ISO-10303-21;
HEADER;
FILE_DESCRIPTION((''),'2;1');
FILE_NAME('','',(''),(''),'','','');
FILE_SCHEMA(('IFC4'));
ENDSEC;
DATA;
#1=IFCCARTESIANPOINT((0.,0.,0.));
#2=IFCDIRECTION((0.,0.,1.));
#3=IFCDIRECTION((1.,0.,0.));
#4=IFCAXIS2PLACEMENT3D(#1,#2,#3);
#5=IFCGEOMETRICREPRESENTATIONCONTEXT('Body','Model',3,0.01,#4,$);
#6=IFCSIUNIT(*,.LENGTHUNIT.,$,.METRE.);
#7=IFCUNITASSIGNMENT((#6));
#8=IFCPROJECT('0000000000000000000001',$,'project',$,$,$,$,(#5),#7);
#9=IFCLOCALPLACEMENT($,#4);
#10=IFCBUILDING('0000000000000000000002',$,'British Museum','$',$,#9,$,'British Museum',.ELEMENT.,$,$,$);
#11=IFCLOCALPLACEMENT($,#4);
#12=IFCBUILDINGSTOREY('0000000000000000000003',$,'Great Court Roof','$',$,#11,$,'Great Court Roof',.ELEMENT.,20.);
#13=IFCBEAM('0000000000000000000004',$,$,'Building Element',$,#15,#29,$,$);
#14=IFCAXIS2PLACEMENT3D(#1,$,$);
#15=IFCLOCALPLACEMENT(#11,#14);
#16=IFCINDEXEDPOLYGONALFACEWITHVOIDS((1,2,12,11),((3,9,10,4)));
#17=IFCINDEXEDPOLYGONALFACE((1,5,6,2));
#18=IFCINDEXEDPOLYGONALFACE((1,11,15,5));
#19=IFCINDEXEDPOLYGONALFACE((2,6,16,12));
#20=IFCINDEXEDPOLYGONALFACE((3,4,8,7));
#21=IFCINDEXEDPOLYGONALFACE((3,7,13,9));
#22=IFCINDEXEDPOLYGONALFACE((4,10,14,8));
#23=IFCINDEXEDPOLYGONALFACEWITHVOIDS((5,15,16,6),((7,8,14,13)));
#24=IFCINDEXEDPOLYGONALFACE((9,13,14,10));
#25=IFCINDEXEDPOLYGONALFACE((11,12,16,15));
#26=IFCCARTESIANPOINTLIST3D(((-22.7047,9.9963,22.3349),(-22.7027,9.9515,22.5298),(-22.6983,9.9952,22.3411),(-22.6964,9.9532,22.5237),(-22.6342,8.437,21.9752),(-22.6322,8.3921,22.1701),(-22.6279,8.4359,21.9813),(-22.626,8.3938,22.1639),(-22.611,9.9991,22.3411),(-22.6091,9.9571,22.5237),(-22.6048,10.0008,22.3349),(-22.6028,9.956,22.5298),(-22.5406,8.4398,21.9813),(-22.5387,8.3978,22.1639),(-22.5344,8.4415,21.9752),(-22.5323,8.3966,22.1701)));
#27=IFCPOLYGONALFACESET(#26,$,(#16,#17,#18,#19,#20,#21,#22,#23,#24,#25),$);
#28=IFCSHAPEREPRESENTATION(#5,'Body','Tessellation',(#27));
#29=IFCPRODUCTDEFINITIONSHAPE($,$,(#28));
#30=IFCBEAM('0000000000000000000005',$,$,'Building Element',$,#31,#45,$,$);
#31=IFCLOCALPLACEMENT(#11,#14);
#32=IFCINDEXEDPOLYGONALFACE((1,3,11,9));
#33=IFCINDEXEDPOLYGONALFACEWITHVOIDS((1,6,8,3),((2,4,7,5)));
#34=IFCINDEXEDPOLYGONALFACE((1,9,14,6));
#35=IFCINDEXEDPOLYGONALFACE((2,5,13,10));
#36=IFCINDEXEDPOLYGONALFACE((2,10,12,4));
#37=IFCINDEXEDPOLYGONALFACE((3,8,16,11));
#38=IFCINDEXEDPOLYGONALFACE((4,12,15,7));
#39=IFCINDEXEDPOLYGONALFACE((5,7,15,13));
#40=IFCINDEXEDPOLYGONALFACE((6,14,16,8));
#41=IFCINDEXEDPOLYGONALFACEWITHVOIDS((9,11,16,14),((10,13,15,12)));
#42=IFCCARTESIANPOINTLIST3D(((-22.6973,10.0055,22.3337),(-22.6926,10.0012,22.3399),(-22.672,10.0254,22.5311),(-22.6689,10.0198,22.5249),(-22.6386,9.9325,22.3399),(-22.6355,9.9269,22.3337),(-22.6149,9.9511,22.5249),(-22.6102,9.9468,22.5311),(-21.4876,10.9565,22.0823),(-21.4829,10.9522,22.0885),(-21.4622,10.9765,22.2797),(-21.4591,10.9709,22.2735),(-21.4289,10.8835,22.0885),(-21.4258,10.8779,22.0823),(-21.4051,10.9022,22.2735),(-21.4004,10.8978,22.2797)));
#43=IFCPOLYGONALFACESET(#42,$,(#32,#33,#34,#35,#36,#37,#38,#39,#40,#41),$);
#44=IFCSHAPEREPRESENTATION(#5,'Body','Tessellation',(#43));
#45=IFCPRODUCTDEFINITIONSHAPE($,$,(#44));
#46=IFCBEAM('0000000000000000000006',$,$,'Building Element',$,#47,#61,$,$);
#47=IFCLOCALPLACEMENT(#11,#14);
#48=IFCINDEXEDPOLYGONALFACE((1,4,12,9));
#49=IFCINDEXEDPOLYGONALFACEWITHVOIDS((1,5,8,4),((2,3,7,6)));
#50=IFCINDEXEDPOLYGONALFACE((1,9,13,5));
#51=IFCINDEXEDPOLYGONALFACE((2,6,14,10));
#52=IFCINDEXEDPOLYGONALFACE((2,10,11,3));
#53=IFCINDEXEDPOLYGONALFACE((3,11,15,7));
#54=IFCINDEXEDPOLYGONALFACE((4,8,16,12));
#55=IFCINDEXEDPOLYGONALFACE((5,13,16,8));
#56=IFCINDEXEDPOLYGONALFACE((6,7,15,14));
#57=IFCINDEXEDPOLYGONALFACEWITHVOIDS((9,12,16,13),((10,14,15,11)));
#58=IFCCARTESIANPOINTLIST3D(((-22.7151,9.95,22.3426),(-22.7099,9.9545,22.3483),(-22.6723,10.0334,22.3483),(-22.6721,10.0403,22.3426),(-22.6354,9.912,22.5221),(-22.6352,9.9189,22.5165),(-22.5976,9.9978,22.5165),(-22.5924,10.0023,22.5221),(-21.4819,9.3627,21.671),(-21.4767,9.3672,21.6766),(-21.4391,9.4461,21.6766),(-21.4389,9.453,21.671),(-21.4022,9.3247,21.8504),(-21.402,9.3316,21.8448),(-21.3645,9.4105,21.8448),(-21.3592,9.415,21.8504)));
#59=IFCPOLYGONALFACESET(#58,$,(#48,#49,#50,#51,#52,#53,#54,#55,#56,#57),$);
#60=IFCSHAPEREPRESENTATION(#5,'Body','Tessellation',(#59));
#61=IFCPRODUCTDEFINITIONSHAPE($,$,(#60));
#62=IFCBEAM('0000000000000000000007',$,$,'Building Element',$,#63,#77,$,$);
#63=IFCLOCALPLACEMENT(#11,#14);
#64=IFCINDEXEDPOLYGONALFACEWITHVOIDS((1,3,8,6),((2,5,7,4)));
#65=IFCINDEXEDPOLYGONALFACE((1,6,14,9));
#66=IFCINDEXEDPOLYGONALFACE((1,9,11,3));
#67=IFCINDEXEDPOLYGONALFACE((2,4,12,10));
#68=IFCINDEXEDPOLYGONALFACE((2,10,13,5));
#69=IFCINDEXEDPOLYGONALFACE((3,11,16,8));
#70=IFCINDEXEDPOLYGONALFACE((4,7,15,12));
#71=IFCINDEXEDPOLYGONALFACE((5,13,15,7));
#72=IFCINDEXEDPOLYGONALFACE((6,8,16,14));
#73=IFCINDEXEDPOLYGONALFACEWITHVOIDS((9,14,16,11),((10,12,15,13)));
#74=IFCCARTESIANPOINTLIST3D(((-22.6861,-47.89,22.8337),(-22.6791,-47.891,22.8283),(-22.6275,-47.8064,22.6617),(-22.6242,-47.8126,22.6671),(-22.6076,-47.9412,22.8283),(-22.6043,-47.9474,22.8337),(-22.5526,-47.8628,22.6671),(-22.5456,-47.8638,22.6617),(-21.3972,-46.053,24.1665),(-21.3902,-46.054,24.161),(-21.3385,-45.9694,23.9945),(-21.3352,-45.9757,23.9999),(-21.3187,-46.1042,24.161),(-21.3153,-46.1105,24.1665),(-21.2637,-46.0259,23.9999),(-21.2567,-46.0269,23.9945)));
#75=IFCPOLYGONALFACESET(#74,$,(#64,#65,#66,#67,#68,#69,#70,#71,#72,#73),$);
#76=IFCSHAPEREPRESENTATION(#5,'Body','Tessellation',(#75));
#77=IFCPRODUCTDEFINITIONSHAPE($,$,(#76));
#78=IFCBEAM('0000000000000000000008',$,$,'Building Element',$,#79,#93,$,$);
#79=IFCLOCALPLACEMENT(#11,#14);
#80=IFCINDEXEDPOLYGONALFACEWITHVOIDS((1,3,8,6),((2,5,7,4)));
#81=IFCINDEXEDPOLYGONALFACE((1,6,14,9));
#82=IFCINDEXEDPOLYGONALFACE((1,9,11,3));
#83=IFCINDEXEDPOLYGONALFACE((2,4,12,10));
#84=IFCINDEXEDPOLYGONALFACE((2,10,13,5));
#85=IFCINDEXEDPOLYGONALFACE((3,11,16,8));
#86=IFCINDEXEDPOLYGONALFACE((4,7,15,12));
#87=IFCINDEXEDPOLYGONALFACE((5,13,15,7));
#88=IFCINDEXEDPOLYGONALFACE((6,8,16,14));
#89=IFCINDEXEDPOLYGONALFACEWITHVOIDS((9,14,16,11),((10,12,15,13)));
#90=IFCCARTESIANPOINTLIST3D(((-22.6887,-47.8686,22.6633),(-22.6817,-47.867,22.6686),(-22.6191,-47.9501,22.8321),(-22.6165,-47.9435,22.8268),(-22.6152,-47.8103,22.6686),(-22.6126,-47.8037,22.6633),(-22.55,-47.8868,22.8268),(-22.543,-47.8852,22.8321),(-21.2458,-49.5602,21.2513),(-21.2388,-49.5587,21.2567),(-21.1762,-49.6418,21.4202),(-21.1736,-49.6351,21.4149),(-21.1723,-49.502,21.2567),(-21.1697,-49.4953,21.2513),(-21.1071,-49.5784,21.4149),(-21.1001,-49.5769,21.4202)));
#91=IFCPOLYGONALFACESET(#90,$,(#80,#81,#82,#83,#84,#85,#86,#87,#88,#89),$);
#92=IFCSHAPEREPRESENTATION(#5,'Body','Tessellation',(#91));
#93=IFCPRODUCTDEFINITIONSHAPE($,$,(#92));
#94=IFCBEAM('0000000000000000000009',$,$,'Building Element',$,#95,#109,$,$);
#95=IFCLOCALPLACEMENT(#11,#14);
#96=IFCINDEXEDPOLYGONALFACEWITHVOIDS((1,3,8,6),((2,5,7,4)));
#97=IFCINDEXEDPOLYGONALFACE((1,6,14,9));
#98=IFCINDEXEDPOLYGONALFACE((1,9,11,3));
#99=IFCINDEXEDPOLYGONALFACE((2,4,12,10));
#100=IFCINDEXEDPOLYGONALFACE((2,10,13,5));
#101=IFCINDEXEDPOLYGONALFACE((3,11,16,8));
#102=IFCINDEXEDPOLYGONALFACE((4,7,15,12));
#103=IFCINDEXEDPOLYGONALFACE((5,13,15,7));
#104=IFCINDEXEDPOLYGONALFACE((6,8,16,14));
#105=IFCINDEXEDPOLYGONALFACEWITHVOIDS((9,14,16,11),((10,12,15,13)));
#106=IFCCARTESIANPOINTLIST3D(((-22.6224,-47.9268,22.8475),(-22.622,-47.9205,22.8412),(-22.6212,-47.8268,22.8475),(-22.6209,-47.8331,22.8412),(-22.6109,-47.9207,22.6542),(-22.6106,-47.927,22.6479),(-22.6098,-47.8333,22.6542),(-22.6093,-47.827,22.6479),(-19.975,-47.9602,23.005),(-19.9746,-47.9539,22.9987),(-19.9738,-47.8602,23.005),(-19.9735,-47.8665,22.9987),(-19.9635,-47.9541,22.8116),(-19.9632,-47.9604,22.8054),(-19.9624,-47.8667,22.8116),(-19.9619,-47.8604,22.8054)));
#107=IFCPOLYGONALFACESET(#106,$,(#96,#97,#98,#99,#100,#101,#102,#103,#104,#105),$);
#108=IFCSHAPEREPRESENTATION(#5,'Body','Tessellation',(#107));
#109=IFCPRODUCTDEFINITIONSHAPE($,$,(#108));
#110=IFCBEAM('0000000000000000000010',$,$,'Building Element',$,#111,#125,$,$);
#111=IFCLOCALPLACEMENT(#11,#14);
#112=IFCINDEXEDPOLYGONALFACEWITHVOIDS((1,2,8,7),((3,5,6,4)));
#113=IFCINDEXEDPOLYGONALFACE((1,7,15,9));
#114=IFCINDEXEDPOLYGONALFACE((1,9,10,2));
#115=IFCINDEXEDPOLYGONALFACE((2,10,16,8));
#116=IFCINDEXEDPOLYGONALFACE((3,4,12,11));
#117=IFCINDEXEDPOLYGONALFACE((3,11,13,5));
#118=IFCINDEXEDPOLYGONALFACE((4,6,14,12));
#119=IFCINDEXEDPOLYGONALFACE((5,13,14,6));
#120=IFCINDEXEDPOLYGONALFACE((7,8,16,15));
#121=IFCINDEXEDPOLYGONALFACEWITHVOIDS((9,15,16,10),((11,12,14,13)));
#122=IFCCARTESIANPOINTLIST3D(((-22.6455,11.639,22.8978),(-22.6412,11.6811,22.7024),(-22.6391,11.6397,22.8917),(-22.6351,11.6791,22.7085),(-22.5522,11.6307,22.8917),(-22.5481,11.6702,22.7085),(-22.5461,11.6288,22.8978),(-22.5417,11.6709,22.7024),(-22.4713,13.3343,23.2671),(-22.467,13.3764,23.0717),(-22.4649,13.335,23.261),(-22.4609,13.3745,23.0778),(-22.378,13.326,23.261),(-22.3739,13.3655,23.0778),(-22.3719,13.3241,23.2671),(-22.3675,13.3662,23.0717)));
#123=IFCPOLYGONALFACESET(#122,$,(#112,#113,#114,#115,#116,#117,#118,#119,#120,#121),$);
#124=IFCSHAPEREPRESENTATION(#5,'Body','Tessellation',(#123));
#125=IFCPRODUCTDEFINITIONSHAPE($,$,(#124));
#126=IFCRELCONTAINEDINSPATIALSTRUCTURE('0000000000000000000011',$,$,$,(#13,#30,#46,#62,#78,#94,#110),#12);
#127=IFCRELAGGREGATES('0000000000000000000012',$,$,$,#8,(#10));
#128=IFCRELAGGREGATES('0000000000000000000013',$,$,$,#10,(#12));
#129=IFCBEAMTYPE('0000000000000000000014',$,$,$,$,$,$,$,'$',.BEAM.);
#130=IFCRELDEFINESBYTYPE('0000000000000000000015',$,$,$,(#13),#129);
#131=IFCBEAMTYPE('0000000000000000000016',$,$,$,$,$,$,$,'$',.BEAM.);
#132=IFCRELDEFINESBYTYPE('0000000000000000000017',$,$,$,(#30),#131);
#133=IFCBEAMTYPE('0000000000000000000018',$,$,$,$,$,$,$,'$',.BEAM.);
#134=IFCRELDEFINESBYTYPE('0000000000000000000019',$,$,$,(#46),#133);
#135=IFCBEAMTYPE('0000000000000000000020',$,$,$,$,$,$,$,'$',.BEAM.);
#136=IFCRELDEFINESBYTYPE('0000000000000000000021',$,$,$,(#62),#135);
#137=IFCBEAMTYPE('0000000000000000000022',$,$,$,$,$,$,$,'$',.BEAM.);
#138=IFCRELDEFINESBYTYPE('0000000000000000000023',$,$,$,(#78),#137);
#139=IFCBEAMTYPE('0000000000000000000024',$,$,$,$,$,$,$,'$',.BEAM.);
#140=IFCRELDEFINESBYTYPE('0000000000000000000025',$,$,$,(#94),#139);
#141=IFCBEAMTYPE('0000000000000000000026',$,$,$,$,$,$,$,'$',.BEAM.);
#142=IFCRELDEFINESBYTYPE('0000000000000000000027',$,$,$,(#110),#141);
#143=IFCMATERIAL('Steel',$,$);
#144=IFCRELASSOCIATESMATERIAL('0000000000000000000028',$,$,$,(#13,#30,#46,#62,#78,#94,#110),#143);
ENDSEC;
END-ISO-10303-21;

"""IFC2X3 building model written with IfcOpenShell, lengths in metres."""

from ifc_helpers import new_model, si_unit, frame, origin_with_axes, origin_2d, place, context, project, spatial, hollow_rectangle, extrude, material, type_object, element, save


model = new_model("IFC2X3")

# Units and contexts
model_context = context("Model", 3, precision=0.01, world=origin_with_axes(), identifier="Body")
ifc_project = project(units=[si_unit("LENGTHUNIT", "METRE")], contexts=[model_context])

# Building, storey
building_placement = place(None, origin_with_axes())
building = spatial("IfcBuilding", under=ifc_project, at=building_placement, Name="British Museum", Description="$", LongName="British Museum", CompositionType="ELEMENT")
storey_placement = place(None, origin_with_axes())
storey = spatial("IfcBuildingStorey", under=building, at=storey_placement, Name="Great Court Roof", Description="$", LongName="Great Court Roof", CompositionType="ELEMENT", Elevation=20.0)

# Beams
ifc_material = material(Name="Steel")
beam_type_1 = type_object("IfcBeamType", ElementType="$", PredefinedType="BEAM")
beam_1_placement = place(None, origin_with_axes())
element("IfcBeam", 1, at=beam_1_placement, inside=storey, type_object=beam_type_1, material=ifc_material, Description="Building Element", context=model_context, shape_type="SweptSolid", body=[
    extrude(hollow_rectangle(XDim=0.1, YDim=0.2, WallThickness=0.0063, InnerFilletRadius=-0.0063, OuterFilletRadius=0.0, at=origin_2d()), frame((-22.6537, 9.9762, 22.4324), z_axis=(0.043983, -0.973458, -0.224599), x_axis=(0.998981, 0.045136, 0.0)), (0.0, 0.0, 1.0), 1.6018),
])
beam_type_2 = type_object("IfcBeamType", ElementType="$", PredefinedType="BEAM")
beam_2_placement = place(None, origin_with_axes())
element("IfcBeam", 2, at=beam_2_placement, inside=storey, type_object=beam_type_2, material=ifc_material, Description="Building Element", context=model_context, shape_type="SweptSolid", body=[
    extrude(hollow_rectangle(XDim=0.1, YDim=0.2, WallThickness=0.0063, InnerFilletRadius=-0.0063, OuterFilletRadius=0.0, at=origin_2d()), frame((-22.6537, 9.9762, 22.4324), z_axis=(0.775872, 0.609945, -0.161211), x_axis=(-0.618029, 0.786155, 0.0)), (0.0, 0.0, 1.0), 1.5592),
])
beam_type_3 = type_object("IfcBeamType", ElementType="$", PredefinedType="BEAM")
beam_3_placement = place(None, origin_with_axes())
element("IfcBeam", 3, at=beam_3_placement, inside=storey, type_object=beam_type_3, material=ifc_material, Description="Building Element", context=model_context, shape_type="SweptSolid", body=[
    extrude(hollow_rectangle(XDim=0.1, YDim=0.2, WallThickness=0.0063, InnerFilletRadius=-0.0063, OuterFilletRadius=0.0, at=origin_2d()), frame((-22.6537, 9.9762, 22.4324), z_axis=(0.810171, -0.385861, -0.441287), x_axis=(0.429993, 0.902832, 0.0)), (0.0, 0.0, 1.0), 1.5221),
])
beam_type_4 = type_object("IfcBeamType", ElementType="$", PredefinedType="BEAM")
beam_4_placement = place(None, origin_with_axes())
element("IfcBeam", 4, at=beam_4_placement, inside=storey, type_object=beam_type_4, material=ifc_material, Description="Building Element", context=model_context, shape_type="SweptSolid", body=[
    extrude(hollow_rectangle(XDim=0.1, YDim=0.2, WallThickness=0.0063, InnerFilletRadius=-0.0063, OuterFilletRadius=0.0, at=origin_2d()), frame((-22.6159, -47.8769, 22.7477), z_axis=(0.493847, 0.703819, 0.510642), x_axis=(-0.81859, 0.574378, 0.0)), (0.0, 0.0, 1.0), 2.61),
])
beam_type_5 = type_object("IfcBeamType", ElementType="$", PredefinedType="BEAM")
beam_5_placement = place(None, origin_with_axes())
element("IfcBeam", 5, at=beam_5_placement, inside=storey, type_object=beam_type_5, material=ifc_material, Description="Building Element", context=model_context, shape_type="SweptSolid", body=[
    extrude(hollow_rectangle(XDim=0.1, YDim=0.2, WallThickness=0.0063, InnerFilletRadius=-0.0063, OuterFilletRadius=0.0, at=origin_2d()), frame((-22.6159, -47.8769, 22.7477), z_axis=(0.547839, -0.642263, -0.53607), x_axis=(0.760818, 0.648965, 0.0)), (0.0, 0.0, 1.0), 2.6339),
])
beam_type_6 = type_object("IfcBeamType", ElementType="$", PredefinedType="BEAM")
beam_6_placement = place(None, origin_with_axes())
element("IfcBeam", 6, at=beam_6_placement, inside=storey, type_object=beam_type_6, material=ifc_material, Description="Building Element", context=model_context, shape_type="SweptSolid", body=[
    extrude(hollow_rectangle(XDim=0.1, YDim=0.2, WallThickness=0.0063, InnerFilletRadius=-0.0063, OuterFilletRadius=0.0, at=origin_2d()), frame((-22.6159, -47.8769, 22.7477), z_axis=(0.998157, -0.012586, 0.059373), x_axis=(0.012608, 0.999921, 0.0)), (0.0, 0.0, 1.0), 2.6523),
])
beam_type_7 = type_object("IfcBeamType", ElementType="$", PredefinedType="BEAM")
beam_7_placement = place(None, origin_with_axes())
element("IfcBeam", 7, at=beam_7_placement, inside=storey, type_object=beam_type_7, material=ifc_material, Description="Building Element", context=model_context, shape_type="SweptSolid", body=[
    extrude(hollow_rectangle(XDim=0.1, YDim=0.2, WallThickness=0.0063, InnerFilletRadius=-0.0063, OuterFilletRadius=0.0, at=origin_2d()), frame((-22.5936, 11.6549, 22.8001), z_axis=(0.099895, 0.972202, 0.211765), x_axis=(-0.994763, 0.102213, 0.0)), (0.0, 0.0, 1.0), 1.7438),
])

save(model, "model.ifc")
